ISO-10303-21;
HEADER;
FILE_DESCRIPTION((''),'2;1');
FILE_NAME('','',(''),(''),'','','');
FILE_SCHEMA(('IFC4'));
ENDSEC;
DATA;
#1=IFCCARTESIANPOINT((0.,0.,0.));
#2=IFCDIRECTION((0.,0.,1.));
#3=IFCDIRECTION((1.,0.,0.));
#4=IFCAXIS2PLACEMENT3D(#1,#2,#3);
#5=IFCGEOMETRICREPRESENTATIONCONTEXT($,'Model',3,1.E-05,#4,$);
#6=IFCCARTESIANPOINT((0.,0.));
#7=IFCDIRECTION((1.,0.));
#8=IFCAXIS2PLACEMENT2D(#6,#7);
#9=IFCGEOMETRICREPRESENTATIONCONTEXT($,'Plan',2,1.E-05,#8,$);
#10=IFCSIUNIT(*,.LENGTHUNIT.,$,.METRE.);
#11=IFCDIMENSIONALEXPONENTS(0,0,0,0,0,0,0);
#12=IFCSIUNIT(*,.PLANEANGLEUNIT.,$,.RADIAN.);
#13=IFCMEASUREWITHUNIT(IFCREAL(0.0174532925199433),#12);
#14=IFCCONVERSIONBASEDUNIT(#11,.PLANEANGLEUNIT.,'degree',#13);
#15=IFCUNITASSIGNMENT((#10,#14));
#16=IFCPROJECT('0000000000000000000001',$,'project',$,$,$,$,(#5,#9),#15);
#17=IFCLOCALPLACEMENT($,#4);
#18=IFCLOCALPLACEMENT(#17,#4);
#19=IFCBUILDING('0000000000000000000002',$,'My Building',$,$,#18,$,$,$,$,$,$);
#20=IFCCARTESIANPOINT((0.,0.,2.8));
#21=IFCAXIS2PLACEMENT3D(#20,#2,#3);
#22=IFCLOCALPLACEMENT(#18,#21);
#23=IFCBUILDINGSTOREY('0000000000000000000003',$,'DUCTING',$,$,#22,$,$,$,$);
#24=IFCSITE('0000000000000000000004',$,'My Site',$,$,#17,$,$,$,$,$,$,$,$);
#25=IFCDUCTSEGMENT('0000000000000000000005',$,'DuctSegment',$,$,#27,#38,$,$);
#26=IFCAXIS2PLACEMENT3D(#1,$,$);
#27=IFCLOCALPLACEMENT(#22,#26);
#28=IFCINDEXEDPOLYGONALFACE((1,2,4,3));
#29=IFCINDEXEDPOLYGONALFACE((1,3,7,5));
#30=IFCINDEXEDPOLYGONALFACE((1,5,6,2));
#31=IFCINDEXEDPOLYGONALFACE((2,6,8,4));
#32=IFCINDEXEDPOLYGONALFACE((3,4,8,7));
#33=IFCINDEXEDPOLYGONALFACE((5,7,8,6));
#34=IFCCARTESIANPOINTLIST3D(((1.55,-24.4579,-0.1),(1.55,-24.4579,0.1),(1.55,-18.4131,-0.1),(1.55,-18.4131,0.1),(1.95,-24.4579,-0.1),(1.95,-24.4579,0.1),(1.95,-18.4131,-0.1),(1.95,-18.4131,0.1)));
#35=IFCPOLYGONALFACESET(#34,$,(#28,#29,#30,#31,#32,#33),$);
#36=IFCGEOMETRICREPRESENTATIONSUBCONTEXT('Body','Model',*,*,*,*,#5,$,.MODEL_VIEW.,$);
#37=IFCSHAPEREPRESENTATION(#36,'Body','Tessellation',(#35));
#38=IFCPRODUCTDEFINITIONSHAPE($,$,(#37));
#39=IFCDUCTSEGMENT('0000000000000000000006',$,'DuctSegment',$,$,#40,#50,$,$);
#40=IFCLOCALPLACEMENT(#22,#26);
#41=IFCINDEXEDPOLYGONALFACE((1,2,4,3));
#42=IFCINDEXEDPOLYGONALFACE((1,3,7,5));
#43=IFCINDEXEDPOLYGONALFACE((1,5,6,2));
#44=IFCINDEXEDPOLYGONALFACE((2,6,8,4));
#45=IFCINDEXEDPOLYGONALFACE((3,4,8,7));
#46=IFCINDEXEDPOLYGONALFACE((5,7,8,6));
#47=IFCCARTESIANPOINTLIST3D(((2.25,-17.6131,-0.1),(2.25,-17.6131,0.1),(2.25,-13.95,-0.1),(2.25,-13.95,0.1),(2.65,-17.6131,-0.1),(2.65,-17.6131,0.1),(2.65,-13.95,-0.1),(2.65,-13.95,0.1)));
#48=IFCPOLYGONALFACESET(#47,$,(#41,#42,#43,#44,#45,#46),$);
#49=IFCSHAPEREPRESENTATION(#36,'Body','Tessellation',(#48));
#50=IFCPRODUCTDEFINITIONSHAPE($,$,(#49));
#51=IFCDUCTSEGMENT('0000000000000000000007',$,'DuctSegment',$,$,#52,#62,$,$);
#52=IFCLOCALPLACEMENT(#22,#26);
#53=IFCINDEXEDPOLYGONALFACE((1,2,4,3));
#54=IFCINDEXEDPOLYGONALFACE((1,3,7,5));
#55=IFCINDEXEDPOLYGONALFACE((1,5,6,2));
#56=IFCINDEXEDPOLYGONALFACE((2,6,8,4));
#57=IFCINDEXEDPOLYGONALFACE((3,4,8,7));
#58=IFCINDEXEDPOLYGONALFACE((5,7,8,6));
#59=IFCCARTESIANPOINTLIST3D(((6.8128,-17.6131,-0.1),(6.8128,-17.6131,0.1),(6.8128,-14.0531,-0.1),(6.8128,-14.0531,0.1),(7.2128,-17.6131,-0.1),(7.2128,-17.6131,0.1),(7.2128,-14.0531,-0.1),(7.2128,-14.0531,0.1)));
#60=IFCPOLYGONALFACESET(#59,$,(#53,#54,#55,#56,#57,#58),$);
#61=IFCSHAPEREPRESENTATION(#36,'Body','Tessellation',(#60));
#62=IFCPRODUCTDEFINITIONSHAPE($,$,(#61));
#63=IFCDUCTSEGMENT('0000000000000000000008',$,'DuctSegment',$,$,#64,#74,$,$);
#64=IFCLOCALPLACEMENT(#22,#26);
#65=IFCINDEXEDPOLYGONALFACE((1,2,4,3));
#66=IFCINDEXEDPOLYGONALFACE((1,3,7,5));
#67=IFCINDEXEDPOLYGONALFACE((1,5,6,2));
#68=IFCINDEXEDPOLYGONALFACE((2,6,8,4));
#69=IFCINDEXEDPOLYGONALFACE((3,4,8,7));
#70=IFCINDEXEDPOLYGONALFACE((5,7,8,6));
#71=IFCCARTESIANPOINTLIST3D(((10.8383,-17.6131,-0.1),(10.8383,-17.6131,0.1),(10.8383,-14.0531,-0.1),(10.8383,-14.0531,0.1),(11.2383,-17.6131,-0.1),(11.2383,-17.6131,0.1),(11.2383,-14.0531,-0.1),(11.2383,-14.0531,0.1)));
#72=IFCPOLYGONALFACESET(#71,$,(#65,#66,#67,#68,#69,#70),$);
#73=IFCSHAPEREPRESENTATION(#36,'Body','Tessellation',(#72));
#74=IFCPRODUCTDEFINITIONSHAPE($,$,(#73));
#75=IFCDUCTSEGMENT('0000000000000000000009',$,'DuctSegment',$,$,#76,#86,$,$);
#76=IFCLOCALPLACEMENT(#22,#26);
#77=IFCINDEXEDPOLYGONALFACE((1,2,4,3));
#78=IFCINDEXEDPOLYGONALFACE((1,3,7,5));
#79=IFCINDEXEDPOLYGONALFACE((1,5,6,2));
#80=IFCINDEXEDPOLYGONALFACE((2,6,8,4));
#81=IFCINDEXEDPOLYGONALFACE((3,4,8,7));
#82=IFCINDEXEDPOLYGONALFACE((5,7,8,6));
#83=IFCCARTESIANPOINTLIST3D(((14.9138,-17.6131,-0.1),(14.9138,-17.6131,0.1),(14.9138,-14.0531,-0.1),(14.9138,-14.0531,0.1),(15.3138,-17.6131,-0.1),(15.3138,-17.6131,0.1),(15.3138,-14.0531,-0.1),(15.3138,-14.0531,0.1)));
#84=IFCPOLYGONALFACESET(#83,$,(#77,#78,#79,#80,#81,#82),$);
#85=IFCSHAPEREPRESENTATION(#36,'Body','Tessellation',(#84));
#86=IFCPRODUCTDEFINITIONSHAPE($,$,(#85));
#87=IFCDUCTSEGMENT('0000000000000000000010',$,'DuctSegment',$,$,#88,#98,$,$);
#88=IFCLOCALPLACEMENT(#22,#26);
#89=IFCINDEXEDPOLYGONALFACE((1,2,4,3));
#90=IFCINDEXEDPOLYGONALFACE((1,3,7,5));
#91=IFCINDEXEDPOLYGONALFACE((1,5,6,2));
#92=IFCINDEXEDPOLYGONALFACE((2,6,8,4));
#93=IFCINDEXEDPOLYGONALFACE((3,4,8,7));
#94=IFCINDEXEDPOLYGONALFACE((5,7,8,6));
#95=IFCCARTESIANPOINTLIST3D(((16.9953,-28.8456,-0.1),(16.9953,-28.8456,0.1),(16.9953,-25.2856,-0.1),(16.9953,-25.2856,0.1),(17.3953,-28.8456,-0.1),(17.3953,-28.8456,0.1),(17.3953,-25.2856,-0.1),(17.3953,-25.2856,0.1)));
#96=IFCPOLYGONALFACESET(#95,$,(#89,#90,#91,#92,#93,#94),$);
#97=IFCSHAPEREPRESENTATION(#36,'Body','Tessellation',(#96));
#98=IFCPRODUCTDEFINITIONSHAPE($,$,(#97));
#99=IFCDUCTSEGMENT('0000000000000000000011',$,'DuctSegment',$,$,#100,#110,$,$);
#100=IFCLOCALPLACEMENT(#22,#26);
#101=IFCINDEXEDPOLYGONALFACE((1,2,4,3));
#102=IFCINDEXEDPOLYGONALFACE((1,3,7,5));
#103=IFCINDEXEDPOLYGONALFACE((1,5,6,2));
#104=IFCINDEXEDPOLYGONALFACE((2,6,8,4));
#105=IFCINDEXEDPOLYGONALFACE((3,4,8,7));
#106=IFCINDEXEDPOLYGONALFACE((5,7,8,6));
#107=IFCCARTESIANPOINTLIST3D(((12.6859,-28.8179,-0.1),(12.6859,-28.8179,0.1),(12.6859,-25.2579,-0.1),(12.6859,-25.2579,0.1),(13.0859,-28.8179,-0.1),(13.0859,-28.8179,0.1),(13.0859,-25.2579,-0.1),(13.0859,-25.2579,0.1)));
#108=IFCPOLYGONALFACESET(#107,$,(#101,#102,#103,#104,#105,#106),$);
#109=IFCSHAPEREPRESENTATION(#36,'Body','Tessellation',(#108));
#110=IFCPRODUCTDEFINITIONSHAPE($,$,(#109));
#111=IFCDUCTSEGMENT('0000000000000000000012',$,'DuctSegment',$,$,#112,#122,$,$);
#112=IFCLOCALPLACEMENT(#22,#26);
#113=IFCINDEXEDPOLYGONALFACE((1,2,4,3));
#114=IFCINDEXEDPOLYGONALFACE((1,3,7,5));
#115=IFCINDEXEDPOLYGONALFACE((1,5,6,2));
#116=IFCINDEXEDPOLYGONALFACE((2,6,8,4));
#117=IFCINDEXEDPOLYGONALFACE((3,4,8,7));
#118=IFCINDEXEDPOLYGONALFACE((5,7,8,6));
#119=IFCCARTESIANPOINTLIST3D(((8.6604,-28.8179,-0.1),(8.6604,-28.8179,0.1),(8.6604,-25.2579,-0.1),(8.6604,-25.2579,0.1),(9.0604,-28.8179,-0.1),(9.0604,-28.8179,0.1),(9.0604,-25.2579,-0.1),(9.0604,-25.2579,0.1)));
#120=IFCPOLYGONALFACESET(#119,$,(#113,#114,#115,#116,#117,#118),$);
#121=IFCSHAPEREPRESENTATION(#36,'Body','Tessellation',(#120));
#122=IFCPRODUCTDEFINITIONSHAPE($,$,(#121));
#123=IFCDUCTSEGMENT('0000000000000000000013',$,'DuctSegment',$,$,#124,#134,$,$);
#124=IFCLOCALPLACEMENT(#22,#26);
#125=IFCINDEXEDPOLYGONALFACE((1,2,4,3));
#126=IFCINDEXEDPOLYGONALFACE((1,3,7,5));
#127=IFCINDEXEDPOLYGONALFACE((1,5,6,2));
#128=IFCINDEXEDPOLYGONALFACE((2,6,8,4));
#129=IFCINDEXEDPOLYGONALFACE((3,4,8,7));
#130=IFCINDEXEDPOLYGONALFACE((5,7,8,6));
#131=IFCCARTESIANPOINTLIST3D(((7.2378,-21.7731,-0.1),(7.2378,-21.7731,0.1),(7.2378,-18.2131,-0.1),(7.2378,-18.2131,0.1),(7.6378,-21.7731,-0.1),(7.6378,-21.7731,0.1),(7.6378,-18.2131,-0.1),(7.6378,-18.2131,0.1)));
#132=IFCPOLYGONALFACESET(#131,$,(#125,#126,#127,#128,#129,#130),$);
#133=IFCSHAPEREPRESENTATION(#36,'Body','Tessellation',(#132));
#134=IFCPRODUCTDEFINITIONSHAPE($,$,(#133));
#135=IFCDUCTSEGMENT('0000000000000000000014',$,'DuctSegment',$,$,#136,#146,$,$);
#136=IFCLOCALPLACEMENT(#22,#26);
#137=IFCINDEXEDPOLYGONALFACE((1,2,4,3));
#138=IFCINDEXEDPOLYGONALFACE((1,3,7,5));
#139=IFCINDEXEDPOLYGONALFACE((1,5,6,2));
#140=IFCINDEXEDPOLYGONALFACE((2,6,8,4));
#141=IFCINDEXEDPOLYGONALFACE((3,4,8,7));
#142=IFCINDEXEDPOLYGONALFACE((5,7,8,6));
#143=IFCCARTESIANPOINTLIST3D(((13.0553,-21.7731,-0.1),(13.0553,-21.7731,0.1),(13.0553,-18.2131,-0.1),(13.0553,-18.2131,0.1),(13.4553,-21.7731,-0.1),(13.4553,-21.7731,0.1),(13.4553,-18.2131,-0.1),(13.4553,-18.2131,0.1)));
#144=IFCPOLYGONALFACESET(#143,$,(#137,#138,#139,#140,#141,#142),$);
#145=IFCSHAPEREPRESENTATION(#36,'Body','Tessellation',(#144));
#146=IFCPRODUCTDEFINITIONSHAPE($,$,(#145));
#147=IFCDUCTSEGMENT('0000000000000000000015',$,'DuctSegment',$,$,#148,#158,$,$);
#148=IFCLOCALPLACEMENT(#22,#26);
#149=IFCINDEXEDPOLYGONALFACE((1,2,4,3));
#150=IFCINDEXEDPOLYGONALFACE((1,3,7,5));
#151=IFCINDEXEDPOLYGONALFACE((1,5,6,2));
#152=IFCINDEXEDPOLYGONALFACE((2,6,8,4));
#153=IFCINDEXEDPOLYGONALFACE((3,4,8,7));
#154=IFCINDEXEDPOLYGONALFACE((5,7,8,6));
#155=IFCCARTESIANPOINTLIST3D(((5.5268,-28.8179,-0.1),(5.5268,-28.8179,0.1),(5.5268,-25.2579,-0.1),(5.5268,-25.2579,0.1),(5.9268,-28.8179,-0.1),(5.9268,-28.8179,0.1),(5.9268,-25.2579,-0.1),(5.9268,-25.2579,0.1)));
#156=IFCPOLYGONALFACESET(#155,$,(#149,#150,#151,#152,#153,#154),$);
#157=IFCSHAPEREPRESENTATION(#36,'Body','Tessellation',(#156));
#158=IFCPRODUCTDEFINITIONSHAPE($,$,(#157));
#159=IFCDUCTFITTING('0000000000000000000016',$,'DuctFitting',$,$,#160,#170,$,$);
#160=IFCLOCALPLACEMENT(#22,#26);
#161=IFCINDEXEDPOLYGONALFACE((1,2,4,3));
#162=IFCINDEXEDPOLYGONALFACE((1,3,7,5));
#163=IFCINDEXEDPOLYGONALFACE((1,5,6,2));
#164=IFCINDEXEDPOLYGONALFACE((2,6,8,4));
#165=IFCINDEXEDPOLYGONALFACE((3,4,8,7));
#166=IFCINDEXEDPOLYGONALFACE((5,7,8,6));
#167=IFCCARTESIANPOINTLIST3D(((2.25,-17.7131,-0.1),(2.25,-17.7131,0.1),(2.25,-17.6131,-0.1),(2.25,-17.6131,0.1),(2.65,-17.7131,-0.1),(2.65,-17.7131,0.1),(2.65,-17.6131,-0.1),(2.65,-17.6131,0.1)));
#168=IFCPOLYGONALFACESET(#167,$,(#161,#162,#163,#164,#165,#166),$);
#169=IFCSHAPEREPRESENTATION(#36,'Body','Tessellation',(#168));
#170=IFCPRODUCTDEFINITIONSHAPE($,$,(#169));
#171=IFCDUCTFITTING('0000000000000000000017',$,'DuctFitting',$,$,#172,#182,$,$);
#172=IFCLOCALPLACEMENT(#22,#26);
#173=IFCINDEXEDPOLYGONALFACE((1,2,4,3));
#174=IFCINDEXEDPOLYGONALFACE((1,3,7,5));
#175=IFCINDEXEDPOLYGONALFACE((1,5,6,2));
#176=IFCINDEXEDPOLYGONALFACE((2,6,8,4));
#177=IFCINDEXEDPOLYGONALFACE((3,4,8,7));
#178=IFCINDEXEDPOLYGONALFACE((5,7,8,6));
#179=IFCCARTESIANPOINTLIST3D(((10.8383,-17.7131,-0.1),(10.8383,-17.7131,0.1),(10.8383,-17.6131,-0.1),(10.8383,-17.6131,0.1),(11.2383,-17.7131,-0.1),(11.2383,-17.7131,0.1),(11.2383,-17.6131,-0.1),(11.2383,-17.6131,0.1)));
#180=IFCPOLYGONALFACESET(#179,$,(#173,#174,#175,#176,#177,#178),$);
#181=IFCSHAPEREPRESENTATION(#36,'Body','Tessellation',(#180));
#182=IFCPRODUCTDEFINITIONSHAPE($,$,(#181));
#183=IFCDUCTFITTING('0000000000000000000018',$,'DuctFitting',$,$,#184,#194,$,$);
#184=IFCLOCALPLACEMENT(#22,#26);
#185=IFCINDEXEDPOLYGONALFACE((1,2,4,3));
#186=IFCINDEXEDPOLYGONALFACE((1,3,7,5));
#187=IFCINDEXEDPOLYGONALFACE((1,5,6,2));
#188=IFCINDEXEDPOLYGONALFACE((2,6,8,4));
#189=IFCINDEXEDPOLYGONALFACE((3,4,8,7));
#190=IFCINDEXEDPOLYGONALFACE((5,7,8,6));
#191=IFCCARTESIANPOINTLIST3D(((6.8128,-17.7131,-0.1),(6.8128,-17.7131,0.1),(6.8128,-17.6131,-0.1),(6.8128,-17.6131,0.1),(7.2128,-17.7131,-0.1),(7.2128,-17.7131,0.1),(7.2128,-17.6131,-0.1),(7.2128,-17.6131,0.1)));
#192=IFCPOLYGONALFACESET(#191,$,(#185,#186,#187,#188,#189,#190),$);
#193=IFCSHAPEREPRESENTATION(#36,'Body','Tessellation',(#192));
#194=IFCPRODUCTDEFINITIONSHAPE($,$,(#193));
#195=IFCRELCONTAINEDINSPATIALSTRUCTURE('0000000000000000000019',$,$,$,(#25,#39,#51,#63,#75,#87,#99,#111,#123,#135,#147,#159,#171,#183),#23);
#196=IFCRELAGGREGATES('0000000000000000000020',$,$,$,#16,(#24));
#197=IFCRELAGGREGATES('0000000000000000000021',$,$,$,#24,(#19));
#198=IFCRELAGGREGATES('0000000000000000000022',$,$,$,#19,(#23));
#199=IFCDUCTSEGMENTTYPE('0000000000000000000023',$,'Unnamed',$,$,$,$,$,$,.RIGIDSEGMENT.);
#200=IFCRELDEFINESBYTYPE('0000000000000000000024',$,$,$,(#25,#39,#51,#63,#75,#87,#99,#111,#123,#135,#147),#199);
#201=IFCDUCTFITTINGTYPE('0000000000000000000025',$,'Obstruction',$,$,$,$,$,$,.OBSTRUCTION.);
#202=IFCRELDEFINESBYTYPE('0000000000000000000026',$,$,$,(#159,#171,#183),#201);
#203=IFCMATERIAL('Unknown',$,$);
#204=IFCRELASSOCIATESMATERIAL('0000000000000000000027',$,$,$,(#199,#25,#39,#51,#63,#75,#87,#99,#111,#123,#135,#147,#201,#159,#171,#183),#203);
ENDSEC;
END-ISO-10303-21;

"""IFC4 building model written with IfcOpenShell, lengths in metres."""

from ifc_helpers import new_model, entity, si_unit, converted_unit, frame, origin_with_axes, origin_2d_with_axis, place, context, subcontext, project, spatial, rectangle, extrude, material, material_profile, profile_set, profile_usage, type_object, element, save


model = new_model("IFC4")

# Units and contexts
model_context = context("Model", 3, precision=1e-05, world=origin_with_axes())
plan_context = context("Plan", 2, precision=1e-05, world=origin_2d_with_axis())
body_context = subcontext(model_context, "Body", "Model", "MODEL_VIEW")
ifc_project = project(units=[si_unit("LENGTHUNIT", "METRE"), converted_unit("PLANEANGLEUNIT", "degree", entity("IfcReal", 0.0174532925199433), si_unit("PLANEANGLEUNIT", "RADIAN"), dimensions=[0, 0, 0, 0, 0, 0, 0])], contexts=[model_context, plan_context])

# Site, building, storey
site_placement = place(None, origin_with_axes())
site = spatial("IfcSite", under=ifc_project, at=site_placement, Name="My Site")
building_placement = place(site_placement, origin_with_axes())
building = spatial("IfcBuilding", under=site, at=building_placement, Name="My Building")
storey_placement = place(building_placement, frame((0.0, 0.0, 2.8), z_axis=(0.0, 0.0, 1.0), x_axis=(1.0, 0.0, 0.0)))
storey = spatial("IfcBuildingStorey", under=building, at=storey_placement, Name="DUCTING")

# Duct segments
ifc_material = material(Name="Unknown")
ifc_material_profile_1 = material_profile(ifc_material, rectangle(XDim=0.4, YDim=0.2))
ifc_profile_set_1 = profile_set([ifc_material_profile_1])
ifc_profile_usage_1 = profile_usage(ifc_profile_set_1, cardinal=5)
duct_segment_type = type_object("IfcDuctSegmentType", Name="Unnamed", PredefinedType="RIGIDSEGMENT", material=ifc_profile_set_1)
duct_segment_1_placement = place(storey_placement, frame((1.75, -24.4579, 0.0), z_axis=(0.0, 1.0, 0.0), x_axis=(-1.0, 0.0, 0.0)))
element("IfcDuctSegment", 1, at=duct_segment_1_placement, inside=storey, type_object=duct_segment_type, material=ifc_profile_usage_1, Name="DuctSegment", context=body_context, shape_type="SweptSolid", body=[
    extrude(rectangle(XDim=0.4, YDim=0.2), origin_with_axes(), (0.0, 0.0, 1.0), 6.0448),
])
ifc_profile_usage_2 = profile_usage(ifc_profile_set_1, cardinal=5)
duct_segment_2_placement = place(storey_placement, frame((2.45, -17.6131, 0.0), z_axis=(0.0, 1.0, 0.0), x_axis=(-1.0, 0.0, 0.0)))
element("IfcDuctSegment", 2, at=duct_segment_2_placement, inside=storey, type_object=duct_segment_type, material=ifc_profile_usage_2, Name="DuctSegment", context=body_context, shape_type="SweptSolid", body=[
    extrude(rectangle(XDim=0.4, YDim=0.2), origin_with_axes(), (0.0, 0.0, 1.0), 3.6631),
])
ifc_profile_usage_3 = profile_usage(ifc_profile_set_1, cardinal=5)
duct_segment_3_placement = place(storey_placement, frame((7.0128, -14.0531, 0.0), z_axis=(0.0, -1.0, 0.0), x_axis=(1.0, 0.0, 0.0)))
element("IfcDuctSegment", 3, at=duct_segment_3_placement, inside=storey, type_object=duct_segment_type, material=ifc_profile_usage_3, Name="DuctSegment", context=body_context, shape_type="SweptSolid", body=[
    extrude(rectangle(XDim=0.4, YDim=0.2), origin_with_axes(), (0.0, 0.0, 1.0), 3.56),
])
ifc_profile_usage_4 = profile_usage(ifc_profile_set_1, cardinal=5)
duct_segment_4_placement = place(storey_placement, frame((11.0383, -14.0531, 0.0), z_axis=(0.0, -1.0, 0.0), x_axis=(1.0, 0.0, 0.0)))
element("IfcDuctSegment", 4, at=duct_segment_4_placement, inside=storey, type_object=duct_segment_type, material=ifc_profile_usage_4, Name="DuctSegment", context=body_context, shape_type="SweptSolid", body=[
    extrude(rectangle(XDim=0.4, YDim=0.2), origin_with_axes(), (0.0, 0.0, 1.0), 3.56),
])
ifc_profile_usage_5 = profile_usage(ifc_profile_set_1, cardinal=5)
duct_segment_5_placement = place(storey_placement, frame((15.1138, -14.0531, 0.0), z_axis=(0.0, -1.0, 0.0), x_axis=(1.0, 0.0, 0.0)))
element("IfcDuctSegment", 5, at=duct_segment_5_placement, inside=storey, type_object=duct_segment_type, material=ifc_profile_usage_5, Name="DuctSegment", context=body_context, shape_type="SweptSolid", body=[
    extrude(rectangle(XDim=0.4, YDim=0.2), origin_with_axes(), (0.0, 0.0, 1.0), 3.56),
])
ifc_profile_usage_6 = profile_usage(ifc_profile_set_1, cardinal=5)
duct_segment_6_placement = place(storey_placement, frame((17.1953, -28.8456, 0.0), z_axis=(0.0, 1.0, 0.0), x_axis=(-1.0, 0.0, 0.0)))
element("IfcDuctSegment", 6, at=duct_segment_6_placement, inside=storey, type_object=duct_segment_type, material=ifc_profile_usage_6, Name="DuctSegment", context=body_context, shape_type="SweptSolid", body=[
    extrude(rectangle(XDim=0.4, YDim=0.2), origin_with_axes(), (0.0, 0.0, 1.0), 3.56),
])
ifc_profile_usage_7 = profile_usage(ifc_profile_set_1, cardinal=5)
duct_segment_7_placement = place(storey_placement, frame((12.8859, -28.8179, 0.0), z_axis=(0.0, 1.0, 0.0), x_axis=(-1.0, 0.0, 0.0)))
element("IfcDuctSegment", 7, at=duct_segment_7_placement, inside=storey, type_object=duct_segment_type, material=ifc_profile_usage_7, Name="DuctSegment", context=body_context, shape_type="SweptSolid", body=[
    extrude(rectangle(XDim=0.4, YDim=0.2), origin_with_axes(), (0.0, 0.0, 1.0), 3.56),
])
ifc_profile_usage_8 = profile_usage(ifc_profile_set_1, cardinal=5)
duct_segment_8_placement = place(storey_placement, frame((8.8604, -28.8179, 0.0), z_axis=(0.0, 1.0, 0.0), x_axis=(-1.0, 0.0, 0.0)))
element("IfcDuctSegment", 8, at=duct_segment_8_placement, inside=storey, type_object=duct_segment_type, material=ifc_profile_usage_8, Name="DuctSegment", context=body_context, shape_type="SweptSolid", body=[
    extrude(rectangle(XDim=0.4, YDim=0.2), origin_with_axes(), (0.0, 0.0, 1.0), 3.56),
])
ifc_profile_usage_9 = profile_usage(ifc_profile_set_1, cardinal=5)
duct_segment_9_placement = place(storey_placement, frame((7.4378, -21.7731, 0.0), z_axis=(0.0, 1.0, 0.0), x_axis=(-1.0, 0.0, 0.0)))
element("IfcDuctSegment", 9, at=duct_segment_9_placement, inside=storey, type_object=duct_segment_type, material=ifc_profile_usage_9, Name="DuctSegment", context=body_context, shape_type="SweptSolid", body=[
    extrude(rectangle(XDim=0.4, YDim=0.2), origin_with_axes(), (0.0, 0.0, 1.0), 3.56),
])
ifc_profile_usage_10 = profile_usage(ifc_profile_set_1, cardinal=5)
duct_segment_10_placement = place(storey_placement, frame((13.2553, -21.7731, 0.0), z_axis=(0.0, 1.0, 0.0), x_axis=(-1.0, 0.0, 0.0)))
element("IfcDuctSegment", 10, at=duct_segment_10_placement, inside=storey, type_object=duct_segment_type, material=ifc_profile_usage_10, Name="DuctSegment", context=body_context, shape_type="SweptSolid", body=[
    extrude(rectangle(XDim=0.4, YDim=0.2), origin_with_axes(), (0.0, 0.0, 1.0), 3.56),
])
ifc_profile_usage_11 = profile_usage(ifc_profile_set_1, cardinal=5)
duct_segment_11_placement = place(storey_placement, frame((5.7268, -28.8179, 0.0), z_axis=(0.0, 1.0, 0.0), x_axis=(-1.0, 0.0, 0.0)))
element("IfcDuctSegment", 11, at=duct_segment_11_placement, inside=storey, type_object=duct_segment_type, material=ifc_profile_usage_11, Name="DuctSegment", context=body_context, shape_type="SweptSolid", body=[
    extrude(rectangle(XDim=0.4, YDim=0.2), origin_with_axes(), (0.0, 0.0, 1.0), 3.56),
])

# Duct fittings
ifc_material_profile_2 = material_profile(ifc_material, rectangle(XDim=0.4, YDim=0.2))
ifc_profile_set_2 = profile_set([ifc_material_profile_2])
ifc_profile_usage_12 = profile_usage(ifc_profile_set_2, cardinal=5)
duct_fitting_type = type_object("IfcDuctFittingType", Name="Obstruction", PredefinedType="OBSTRUCTION", material=ifc_profile_set_2)
duct_fitting_1_placement = place(storey_placement, frame((2.45, -17.7131, 0.0), z_axis=(0.0, 1.0, 0.0), x_axis=(-1.0, 0.0, 0.0)))
element("IfcDuctFitting", 12, at=duct_fitting_1_placement, inside=storey, type_object=duct_fitting_type, material=ifc_profile_usage_12, Name="DuctFitting", context=body_context, shape_type="SweptSolid", body=[
    extrude(rectangle(XDim=0.4, YDim=0.2), origin_with_axes(), (0.0, 0.0, 1.0), 0.1),
])
ifc_profile_usage_13 = profile_usage(ifc_profile_set_2, cardinal=5)
duct_fitting_2_placement = place(storey_placement, frame((11.0383, -17.6131, 0.0), z_axis=(0.0, -1.0, 0.0), x_axis=(1.0, 0.0, 0.0)))
element("IfcDuctFitting", 13, at=duct_fitting_2_placement, inside=storey, type_object=duct_fitting_type, material=ifc_profile_usage_13, Name="DuctFitting", context=body_context, shape_type="SweptSolid", body=[
    extrude(rectangle(XDim=0.4, YDim=0.2), origin_with_axes(), (0.0, 0.0, 1.0), 0.1),
])
ifc_profile_usage_14 = profile_usage(ifc_profile_set_2, cardinal=5)
duct_fitting_3_placement = place(storey_placement, frame((7.0128, -17.6131, 0.0), z_axis=(0.0, -1.0, 0.0), x_axis=(1.0, 0.0, 0.0)))
element("IfcDuctFitting", 14, at=duct_fitting_3_placement, inside=storey, type_object=duct_fitting_type, material=ifc_profile_usage_14, Name="DuctFitting", context=body_context, shape_type="SweptSolid", body=[
    extrude(rectangle(XDim=0.4, YDim=0.2), origin_with_axes(), (0.0, 0.0, 1.0), 0.1),
])

save(model, "model.ifc")
